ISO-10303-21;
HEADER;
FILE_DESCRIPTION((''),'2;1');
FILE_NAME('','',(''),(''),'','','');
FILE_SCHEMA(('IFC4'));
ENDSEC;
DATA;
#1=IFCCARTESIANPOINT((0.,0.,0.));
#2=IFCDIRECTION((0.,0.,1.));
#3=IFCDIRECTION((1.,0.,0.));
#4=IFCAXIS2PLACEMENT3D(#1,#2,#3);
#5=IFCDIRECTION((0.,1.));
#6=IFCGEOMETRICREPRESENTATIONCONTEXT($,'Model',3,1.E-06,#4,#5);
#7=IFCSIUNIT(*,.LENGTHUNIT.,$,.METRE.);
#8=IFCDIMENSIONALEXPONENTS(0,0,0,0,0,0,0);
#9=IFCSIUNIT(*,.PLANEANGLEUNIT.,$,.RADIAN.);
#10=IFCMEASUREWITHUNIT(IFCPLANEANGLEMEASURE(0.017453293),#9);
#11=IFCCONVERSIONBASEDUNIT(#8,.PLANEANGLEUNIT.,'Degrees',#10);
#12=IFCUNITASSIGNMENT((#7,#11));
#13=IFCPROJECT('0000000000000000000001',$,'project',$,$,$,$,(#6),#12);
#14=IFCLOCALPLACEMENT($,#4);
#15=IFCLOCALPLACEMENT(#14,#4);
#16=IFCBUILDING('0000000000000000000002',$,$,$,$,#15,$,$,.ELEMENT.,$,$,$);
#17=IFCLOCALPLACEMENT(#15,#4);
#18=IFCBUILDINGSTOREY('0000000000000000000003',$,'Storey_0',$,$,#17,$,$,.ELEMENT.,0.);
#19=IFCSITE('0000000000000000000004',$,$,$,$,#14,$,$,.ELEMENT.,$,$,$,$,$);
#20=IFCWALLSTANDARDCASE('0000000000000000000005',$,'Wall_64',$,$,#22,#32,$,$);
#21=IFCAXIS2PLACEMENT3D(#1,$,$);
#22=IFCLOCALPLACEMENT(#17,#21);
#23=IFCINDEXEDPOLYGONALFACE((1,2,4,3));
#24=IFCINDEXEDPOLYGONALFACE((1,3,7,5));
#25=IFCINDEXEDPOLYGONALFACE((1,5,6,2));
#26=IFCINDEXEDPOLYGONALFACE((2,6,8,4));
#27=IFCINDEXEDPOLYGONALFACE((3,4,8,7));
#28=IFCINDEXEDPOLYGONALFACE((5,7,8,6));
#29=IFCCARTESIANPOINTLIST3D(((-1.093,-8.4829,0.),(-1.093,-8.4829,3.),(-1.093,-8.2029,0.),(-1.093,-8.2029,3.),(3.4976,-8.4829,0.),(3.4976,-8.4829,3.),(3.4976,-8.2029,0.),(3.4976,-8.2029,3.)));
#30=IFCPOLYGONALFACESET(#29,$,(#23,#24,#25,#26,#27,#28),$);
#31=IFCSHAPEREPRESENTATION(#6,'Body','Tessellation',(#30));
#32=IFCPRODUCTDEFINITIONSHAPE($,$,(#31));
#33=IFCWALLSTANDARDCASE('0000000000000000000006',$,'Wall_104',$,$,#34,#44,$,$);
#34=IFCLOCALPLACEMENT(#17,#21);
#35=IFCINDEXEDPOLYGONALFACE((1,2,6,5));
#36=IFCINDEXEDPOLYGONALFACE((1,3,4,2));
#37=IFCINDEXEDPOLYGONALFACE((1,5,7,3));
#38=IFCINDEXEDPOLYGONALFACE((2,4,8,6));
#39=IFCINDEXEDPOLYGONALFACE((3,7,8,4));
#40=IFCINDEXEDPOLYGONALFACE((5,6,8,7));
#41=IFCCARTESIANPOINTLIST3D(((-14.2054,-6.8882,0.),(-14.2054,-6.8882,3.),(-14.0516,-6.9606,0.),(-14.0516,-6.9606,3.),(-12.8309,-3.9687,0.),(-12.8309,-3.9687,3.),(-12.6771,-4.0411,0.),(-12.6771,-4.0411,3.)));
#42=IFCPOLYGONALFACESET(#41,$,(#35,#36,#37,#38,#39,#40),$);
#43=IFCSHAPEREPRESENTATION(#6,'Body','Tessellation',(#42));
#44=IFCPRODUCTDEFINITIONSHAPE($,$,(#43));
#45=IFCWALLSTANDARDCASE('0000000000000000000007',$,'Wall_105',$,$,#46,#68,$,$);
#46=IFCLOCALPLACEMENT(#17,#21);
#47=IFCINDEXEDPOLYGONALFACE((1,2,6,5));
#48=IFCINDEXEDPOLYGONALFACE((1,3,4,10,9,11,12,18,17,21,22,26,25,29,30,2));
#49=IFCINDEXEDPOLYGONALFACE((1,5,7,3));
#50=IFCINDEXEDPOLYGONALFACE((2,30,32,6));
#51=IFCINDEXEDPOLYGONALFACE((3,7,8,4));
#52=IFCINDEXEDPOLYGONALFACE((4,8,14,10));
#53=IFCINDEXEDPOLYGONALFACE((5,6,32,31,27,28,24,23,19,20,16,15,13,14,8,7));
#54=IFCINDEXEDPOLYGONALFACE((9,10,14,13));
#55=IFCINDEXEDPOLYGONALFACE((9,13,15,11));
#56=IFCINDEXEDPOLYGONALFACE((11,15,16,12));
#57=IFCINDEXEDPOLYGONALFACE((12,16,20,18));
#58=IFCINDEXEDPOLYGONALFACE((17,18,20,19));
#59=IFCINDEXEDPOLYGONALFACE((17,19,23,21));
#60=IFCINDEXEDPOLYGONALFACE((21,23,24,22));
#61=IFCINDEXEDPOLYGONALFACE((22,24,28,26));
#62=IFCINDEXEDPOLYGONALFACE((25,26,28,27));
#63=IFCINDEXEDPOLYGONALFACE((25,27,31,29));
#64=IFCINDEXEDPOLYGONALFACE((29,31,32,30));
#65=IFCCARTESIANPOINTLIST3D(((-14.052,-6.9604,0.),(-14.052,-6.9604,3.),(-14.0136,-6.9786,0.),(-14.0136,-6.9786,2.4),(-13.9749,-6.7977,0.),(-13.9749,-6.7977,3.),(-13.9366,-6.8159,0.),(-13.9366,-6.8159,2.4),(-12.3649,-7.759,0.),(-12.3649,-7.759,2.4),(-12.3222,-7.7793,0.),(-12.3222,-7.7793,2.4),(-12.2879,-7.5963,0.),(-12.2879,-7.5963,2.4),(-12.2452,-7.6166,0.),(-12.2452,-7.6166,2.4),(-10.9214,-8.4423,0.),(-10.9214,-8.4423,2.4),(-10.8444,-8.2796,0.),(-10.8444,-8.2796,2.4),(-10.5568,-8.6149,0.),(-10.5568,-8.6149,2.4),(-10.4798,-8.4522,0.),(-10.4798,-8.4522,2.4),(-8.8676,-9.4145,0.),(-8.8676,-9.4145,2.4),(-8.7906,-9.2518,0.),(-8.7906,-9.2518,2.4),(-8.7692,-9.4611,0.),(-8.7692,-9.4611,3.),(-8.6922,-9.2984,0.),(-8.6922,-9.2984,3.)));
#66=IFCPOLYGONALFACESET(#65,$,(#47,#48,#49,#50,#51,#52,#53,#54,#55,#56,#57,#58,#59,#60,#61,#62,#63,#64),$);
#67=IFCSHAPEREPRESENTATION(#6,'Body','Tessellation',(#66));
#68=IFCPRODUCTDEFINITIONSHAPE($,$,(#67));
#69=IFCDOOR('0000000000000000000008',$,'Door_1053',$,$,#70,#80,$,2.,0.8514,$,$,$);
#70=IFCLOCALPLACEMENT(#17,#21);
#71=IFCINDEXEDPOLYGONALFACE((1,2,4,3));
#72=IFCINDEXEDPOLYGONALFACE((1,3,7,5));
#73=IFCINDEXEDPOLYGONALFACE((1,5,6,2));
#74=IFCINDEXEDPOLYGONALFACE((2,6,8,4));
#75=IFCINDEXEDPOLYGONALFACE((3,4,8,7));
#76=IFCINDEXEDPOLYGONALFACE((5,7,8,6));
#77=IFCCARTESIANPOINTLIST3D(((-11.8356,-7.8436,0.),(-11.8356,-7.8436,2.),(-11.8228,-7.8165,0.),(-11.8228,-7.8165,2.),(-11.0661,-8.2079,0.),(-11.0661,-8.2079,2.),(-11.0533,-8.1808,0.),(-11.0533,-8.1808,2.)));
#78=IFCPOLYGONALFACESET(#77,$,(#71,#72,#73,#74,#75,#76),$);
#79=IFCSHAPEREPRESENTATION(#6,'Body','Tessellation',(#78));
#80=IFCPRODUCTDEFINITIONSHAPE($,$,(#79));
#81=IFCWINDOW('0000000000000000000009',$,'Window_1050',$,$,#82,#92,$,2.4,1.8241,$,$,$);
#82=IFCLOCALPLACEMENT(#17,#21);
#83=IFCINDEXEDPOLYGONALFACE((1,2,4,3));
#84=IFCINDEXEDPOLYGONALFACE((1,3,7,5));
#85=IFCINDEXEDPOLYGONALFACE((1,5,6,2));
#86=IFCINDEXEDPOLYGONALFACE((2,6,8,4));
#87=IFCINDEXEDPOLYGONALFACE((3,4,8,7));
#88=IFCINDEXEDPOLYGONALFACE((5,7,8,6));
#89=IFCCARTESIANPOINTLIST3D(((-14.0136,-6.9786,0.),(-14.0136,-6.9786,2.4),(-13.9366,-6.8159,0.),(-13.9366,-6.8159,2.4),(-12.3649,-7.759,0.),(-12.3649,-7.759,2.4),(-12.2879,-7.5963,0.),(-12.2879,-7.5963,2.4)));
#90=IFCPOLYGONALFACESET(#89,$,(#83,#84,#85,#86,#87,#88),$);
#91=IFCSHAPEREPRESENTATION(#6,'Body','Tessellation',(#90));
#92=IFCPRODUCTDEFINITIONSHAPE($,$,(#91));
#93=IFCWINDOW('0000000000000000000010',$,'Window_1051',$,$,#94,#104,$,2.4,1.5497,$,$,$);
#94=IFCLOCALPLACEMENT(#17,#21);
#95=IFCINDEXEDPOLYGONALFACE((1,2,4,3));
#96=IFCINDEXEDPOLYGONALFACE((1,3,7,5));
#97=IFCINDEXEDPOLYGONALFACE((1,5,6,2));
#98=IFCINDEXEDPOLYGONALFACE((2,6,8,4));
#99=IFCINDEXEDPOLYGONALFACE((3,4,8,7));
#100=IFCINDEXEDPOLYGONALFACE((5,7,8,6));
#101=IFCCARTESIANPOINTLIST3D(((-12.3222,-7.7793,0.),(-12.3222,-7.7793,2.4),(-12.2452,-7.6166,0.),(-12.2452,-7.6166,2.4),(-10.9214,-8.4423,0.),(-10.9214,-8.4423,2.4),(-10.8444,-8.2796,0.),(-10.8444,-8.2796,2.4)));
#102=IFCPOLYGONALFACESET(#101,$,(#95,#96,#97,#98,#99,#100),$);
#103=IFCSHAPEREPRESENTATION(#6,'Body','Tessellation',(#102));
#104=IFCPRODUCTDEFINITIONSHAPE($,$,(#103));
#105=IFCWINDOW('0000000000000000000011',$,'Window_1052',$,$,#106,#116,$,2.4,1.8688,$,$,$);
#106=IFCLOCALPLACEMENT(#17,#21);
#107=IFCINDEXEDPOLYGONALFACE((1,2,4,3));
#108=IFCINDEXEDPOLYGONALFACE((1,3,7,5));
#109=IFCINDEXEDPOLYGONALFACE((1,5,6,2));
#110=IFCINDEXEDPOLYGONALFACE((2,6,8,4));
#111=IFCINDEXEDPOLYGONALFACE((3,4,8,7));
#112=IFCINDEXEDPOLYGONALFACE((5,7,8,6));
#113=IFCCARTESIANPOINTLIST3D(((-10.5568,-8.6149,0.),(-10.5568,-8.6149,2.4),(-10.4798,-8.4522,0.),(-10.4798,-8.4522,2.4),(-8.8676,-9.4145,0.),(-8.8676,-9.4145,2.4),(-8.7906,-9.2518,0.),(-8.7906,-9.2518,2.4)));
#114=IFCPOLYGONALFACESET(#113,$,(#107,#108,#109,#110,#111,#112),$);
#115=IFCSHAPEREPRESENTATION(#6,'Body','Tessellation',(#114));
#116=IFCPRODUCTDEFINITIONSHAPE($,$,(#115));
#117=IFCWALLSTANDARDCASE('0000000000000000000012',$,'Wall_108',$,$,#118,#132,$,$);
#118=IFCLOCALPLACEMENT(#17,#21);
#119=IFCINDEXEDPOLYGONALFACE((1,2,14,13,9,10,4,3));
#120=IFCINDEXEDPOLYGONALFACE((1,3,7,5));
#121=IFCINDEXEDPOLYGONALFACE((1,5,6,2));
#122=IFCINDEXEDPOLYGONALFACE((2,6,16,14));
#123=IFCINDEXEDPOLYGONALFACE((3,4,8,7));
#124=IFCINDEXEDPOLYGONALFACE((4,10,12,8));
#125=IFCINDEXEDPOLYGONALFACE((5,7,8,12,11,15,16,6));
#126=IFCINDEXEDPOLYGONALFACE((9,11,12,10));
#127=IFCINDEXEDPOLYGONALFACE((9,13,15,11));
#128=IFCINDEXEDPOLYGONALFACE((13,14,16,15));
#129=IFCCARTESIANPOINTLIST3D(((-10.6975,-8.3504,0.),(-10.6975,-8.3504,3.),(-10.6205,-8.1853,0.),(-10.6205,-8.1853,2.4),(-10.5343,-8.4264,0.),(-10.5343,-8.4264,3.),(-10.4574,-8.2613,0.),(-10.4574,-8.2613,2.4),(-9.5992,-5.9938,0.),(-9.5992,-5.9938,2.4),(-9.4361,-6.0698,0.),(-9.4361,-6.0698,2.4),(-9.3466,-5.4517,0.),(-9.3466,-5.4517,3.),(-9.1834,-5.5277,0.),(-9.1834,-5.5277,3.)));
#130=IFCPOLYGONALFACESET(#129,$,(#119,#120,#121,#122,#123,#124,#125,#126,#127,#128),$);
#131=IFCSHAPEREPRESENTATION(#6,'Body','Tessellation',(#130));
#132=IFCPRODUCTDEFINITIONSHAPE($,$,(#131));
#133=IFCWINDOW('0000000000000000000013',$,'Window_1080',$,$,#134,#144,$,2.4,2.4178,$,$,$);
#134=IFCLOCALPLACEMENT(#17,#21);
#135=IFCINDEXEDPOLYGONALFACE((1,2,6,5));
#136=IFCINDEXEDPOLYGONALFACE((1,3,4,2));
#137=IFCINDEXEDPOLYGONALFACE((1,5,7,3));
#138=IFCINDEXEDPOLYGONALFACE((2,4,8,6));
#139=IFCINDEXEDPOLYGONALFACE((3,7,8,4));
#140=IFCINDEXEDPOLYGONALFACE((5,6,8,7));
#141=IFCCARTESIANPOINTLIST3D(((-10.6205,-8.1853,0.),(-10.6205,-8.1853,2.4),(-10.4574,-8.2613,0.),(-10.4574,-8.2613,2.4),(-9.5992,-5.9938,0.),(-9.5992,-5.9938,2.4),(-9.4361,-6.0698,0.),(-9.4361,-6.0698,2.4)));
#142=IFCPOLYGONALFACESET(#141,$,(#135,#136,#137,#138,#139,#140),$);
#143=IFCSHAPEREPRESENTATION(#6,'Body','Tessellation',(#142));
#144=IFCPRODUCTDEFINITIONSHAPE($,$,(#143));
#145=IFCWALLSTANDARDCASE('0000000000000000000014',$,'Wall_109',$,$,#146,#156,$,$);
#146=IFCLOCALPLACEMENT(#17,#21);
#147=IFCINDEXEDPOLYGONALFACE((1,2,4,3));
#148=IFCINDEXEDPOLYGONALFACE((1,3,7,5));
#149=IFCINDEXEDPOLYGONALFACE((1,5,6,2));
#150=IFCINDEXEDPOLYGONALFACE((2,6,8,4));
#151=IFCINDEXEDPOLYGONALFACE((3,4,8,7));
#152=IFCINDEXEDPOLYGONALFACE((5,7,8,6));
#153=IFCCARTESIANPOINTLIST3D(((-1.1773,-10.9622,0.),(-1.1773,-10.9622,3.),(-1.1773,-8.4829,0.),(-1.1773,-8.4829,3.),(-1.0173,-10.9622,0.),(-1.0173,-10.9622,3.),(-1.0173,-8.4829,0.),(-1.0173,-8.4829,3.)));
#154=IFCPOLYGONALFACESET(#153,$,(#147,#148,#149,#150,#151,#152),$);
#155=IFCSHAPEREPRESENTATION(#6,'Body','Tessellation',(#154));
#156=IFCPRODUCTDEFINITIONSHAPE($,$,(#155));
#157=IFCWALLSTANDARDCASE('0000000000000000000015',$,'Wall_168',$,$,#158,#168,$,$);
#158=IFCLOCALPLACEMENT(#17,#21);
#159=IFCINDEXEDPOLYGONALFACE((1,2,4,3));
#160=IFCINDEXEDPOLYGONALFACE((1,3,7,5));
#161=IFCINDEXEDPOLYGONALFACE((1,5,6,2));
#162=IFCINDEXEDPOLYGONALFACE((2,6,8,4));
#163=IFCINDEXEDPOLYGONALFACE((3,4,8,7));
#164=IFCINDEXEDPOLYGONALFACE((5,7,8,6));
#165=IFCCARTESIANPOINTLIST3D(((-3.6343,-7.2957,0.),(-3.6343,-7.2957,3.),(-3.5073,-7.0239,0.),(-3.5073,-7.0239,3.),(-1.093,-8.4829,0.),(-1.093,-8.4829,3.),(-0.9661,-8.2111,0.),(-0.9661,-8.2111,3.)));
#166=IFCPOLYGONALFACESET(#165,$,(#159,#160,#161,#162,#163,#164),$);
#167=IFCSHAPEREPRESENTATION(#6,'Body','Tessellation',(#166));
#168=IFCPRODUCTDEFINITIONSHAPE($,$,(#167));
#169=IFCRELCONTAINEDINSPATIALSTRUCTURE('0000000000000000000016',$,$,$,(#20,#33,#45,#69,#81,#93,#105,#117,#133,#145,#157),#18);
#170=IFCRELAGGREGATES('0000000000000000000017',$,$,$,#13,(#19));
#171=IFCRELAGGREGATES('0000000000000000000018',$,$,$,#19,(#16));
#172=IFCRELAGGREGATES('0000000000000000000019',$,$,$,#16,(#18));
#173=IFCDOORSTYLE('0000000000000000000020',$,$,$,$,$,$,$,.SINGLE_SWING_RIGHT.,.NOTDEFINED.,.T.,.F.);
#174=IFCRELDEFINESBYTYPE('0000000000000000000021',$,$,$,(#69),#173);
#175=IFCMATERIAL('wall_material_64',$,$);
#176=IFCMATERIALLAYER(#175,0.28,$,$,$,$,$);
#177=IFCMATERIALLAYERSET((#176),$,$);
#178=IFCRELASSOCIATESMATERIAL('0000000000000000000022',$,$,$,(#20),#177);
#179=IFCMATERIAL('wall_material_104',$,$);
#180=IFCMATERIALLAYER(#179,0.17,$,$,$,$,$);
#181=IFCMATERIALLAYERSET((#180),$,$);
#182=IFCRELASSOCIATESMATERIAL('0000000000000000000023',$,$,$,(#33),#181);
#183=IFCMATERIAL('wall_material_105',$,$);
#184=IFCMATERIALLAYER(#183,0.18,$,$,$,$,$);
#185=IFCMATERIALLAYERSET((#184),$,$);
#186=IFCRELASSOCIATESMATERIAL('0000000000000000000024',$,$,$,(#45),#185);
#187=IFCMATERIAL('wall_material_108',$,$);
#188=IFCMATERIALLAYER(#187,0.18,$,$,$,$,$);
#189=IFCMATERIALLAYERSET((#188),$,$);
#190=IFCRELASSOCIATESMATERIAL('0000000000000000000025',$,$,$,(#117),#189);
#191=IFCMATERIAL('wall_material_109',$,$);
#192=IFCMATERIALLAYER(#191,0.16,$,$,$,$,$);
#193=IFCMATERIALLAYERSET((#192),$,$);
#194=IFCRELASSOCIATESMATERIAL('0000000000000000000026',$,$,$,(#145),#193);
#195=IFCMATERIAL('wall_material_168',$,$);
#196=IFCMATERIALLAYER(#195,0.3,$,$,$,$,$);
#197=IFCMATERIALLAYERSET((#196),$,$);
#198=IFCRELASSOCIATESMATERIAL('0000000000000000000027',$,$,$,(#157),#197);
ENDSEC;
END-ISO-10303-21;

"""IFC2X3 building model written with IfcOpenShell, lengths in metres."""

from ifc_helpers import new_model, entity, si_unit, converted_unit, direction, frame, frame_2d, origin_with_axes, place, context, project, spatial, polyline, rectangle, outline, extrude, material, layer, layer_set, layer_usage, type_object, element, fill, save


model = new_model("IFC2X3")

# Units and contexts
model_context = context("Model", 3, precision=1e-06, world=origin_with_axes(), true_north=direction((0.0, 1.0)))
ifc_project = project(units=[si_unit("LENGTHUNIT", "METRE"), converted_unit("PLANEANGLEUNIT", "Degrees", entity("IfcPlaneAngleMeasure", 0.017453293), si_unit("PLANEANGLEUNIT", "RADIAN"), dimensions=[0, 0, 0, 0, 0, 0, 0])], contexts=[model_context])

# Site, building, storey
site_placement = place(None, origin_with_axes())
site = spatial("IfcSite", under=ifc_project, at=site_placement, CompositionType="ELEMENT")
building_placement = place(site_placement, origin_with_axes())
building = spatial("IfcBuilding", under=site, at=building_placement, CompositionType="ELEMENT")
storey_placement = place(building_placement, origin_with_axes())
storey = spatial("IfcBuildingStorey", under=building, at=storey_placement, Name="Storey_0", CompositionType="ELEMENT", Elevation=0.0)

# Walls
ifc_material_1 = material(Name="wall_material_64")
ifc_layer_1 = layer(ifc_material_1, 0.28)
ifc_layer_set_1 = layer_set([ifc_layer_1])
ifc_layer_usage_1 = layer_usage(ifc_layer_set_1, "AXIS2", "NEGATIVE", 0.0)
wall_1_placement = place(storey_placement, frame((-1.093, -8.2029, 0.0), z_axis=(0.0, 0.0, 1.0), x_axis=(1.0, 0.0, 0.0)))
element("IfcWallStandardCase", 1, at=wall_1_placement, inside=storey, material=ifc_layer_usage_1, Name="Wall_64", context=model_context, shape_type="SweptSolid", body=[
    extrude(outline(polyline([(0.0, 0.0), (4.5907, 0.0), (4.5907, -0.28), (0.0, -0.28), (0.0, 0.0)])), origin_with_axes(), (0.0, 0.0, 1.0), 3.0),
])
ifc_material_2 = material(Name="wall_material_104")
ifc_layer_2 = layer(ifc_material_2, 0.17)
ifc_layer_set_2 = layer_set([ifc_layer_2])
ifc_layer_usage_2 = layer_usage(ifc_layer_set_2, "AXIS2", "POSITIVE", 0.0)
wall_2_placement = place(storey_placement, frame((-12.8309, -3.9687, 0.0), z_axis=(0.0, 0.0, 1.0), x_axis=(-0.425973, -0.904736, 0.0)))
element("IfcWallStandardCase", 2, at=wall_2_placement, inside=storey, material=ifc_layer_usage_2, Name="Wall_104", context=model_context, shape_type="SweptSolid", body=[
    extrude(outline(polyline([(0.0, 0.17), (3.2269, 0.17), (3.2269, 0.0), (0.0, 0.0), (0.0, 0.17)])), origin_with_axes(), (0.0, 0.0, 1.0), 3.0),
])

# Wall, openings, door, windows
ifc_material_3 = material(Name="wall_material_105")
ifc_layer_3 = layer(ifc_material_3, 0.18)
ifc_layer_set_3 = layer_set([ifc_layer_3])
ifc_layer_usage_3 = layer_usage(ifc_layer_set_3, "AXIS2", "POSITIVE", 0.0)
wall_3_placement = place(storey_placement, frame((-14.052, -6.9604, 0.0), z_axis=(0.0, 0.0, 1.0), x_axis=(0.90385, -0.42785, 0.0)))
wall_3 = element("IfcWallStandardCase", 3, at=wall_3_placement, inside=storey, material=ifc_layer_usage_3, Name="Wall_105", context=model_context, shape_type="SweptSolid", body=[
    extrude(outline(polyline([(0.0, 0.18), (5.8447, 0.18), (5.8447, 0.0), (0.0, 0.0), (0.0, 0.18)])), origin_with_axes(), (0.0, 0.0, 1.0), 3.0),
])
opening_1_placement = place(wall_3_placement, frame((0.0424, 0.18, 0.0), z_axis=(0.0, 0.0, 1.0), x_axis=(1.0, 0.0, 0.0)))
opening_1 = element("IfcOpeningElement", 4, at=opening_1_placement, cuts=wall_3, context=model_context, shape_type="SweptSolid", body=[
    extrude(rectangle(XDim=1.8241, YDim=2.4, at=frame_2d((1.2, -0.912), x_axis=(0.0, 1.0))), frame((0.0, 0.01, 0.0), z_axis=(0.0, -1.0, 0.0), x_axis=(0.0, 0.0, 1.0)), (0.0, 0.0, 1.0), 0.2),
])
opening_2_placement = place(wall_3_placement, frame((1.9138, 0.18, 0.0), z_axis=(0.0, 0.0, 1.0), x_axis=(1.0, 0.0, 0.0)))
opening_2 = element("IfcOpeningElement", 5, at=opening_2_placement, cuts=wall_3, context=model_context, shape_type="SweptSolid", body=[
    extrude(rectangle(XDim=1.5497, YDim=2.4, at=frame_2d((1.2, -0.7749), x_axis=(0.0, 1.0))), frame((0.0, 0.01, 0.0), z_axis=(0.0, -1.0, 0.0), x_axis=(0.0, 0.0, 1.0)), (0.0, 0.0, 1.0), 0.2),
])
opening_3_placement = place(wall_3_placement, frame((3.867, 0.18, 0.0), z_axis=(0.0, 0.0, 1.0), x_axis=(1.0, 0.0, 0.0)))
opening_3 = element("IfcOpeningElement", 6, at=opening_3_placement, cuts=wall_3, context=model_context, shape_type="SweptSolid", body=[
    extrude(rectangle(XDim=1.8688, YDim=2.4, at=frame_2d((1.2, -0.9344), x_axis=(0.0, 1.0))), frame((0.0, 0.01, 0.0), z_axis=(0.0, -1.0, 0.0), x_axis=(0.0, 0.0, 1.0)), (0.0, 0.0, 1.0), 0.2),
])
opening_4_placement = place(wall_3_placement, frame((2.3811, 0.18, 0.0), z_axis=(0.0, 0.0, 1.0), x_axis=(1.0, 0.0, 0.0)))
opening_4 = element("IfcOpeningElement", 7, at=opening_4_placement, cuts=wall_3, context=model_context, shape_type="SweptSolid", body=[
    extrude(rectangle(XDim=0.8514, YDim=2.0, at=frame_2d((1.0, -0.4257), x_axis=(0.0, 1.0))), frame((0.0, 0.01, 0.0), z_axis=(0.0, -1.0, 0.0), x_axis=(0.0, 0.0, 1.0)), (0.0, 0.0, 1.0), 0.2),
])
door_style = type_object("IfcDoorStyle", ConstructionType="NOTDEFINED", OperationType="SINGLE_SWING_RIGHT", ParameterTakesPrecedence=True, Sizeable=False)
door_placement = place(storey_placement, origin_with_axes())
door = element("IfcDoor", 8, at=door_placement, inside=storey, type_object=door_style, Name="Door_1053", OverallHeight=2.0, OverallWidth=0.8514, context=model_context, shape_type="SweptSolid", body=[
    extrude(outline(polyline([(-11.8228, -7.8165), (-11.0533, -8.1808), (-11.0661, -8.2079), (-11.8356, -7.8436), (-11.8228, -7.8165)])), origin_with_axes(), (0.0, 0.0, 1.0), 2.0),
])
fill(opening_4, door)
window_1_placement = place(storey_placement, origin_with_axes())
window_1 = element("IfcWindow", 9, at=window_1_placement, inside=storey, Name="Window_1050", OverallHeight=2.4, OverallWidth=1.8241, context=model_context, shape_type="SweptSolid", body=[
    extrude(outline(polyline([(-13.9366, -6.8159), (-12.2879, -7.5963), (-12.3649, -7.759), (-14.0136, -6.9786), (-13.9366, -6.8159)])), origin_with_axes(), (0.0, 0.0, 1.0), 2.4),
])
fill(opening_1, window_1)
window_2_placement = place(storey_placement, origin_with_axes())
window_2 = element("IfcWindow", 10, at=window_2_placement, inside=storey, Name="Window_1051", OverallHeight=2.4, OverallWidth=1.5497, context=model_context, shape_type="SweptSolid", body=[
    extrude(outline(polyline([(-12.2452, -7.6166), (-10.8444, -8.2796), (-10.9214, -8.4423), (-12.3222, -7.7793), (-12.2452, -7.6166)])), origin_with_axes(), (0.0, 0.0, 1.0), 2.4),
])
fill(opening_2, window_2)
window_3_placement = place(storey_placement, origin_with_axes())
window_3 = element("IfcWindow", 11, at=window_3_placement, inside=storey, Name="Window_1052", OverallHeight=2.4, OverallWidth=1.8688, context=model_context, shape_type="SweptSolid", body=[
    extrude(outline(polyline([(-10.4798, -8.4522), (-8.7906, -9.2518), (-8.8676, -9.4145), (-10.5568, -8.6149), (-10.4798, -8.4522)])), origin_with_axes(), (0.0, 0.0, 1.0), 2.4),
])
fill(opening_3, window_3)

# Wall, opening, window
ifc_material_4 = material(Name="wall_material_108")
ifc_layer_4 = layer(ifc_material_4, 0.18)
ifc_layer_set_4 = layer_set([ifc_layer_4])
ifc_layer_usage_4 = layer_usage(ifc_layer_set_4, "AXIS2", "NEGATIVE", 0.0)
wall_4_placement = place(storey_placement, frame((-10.6975, -8.3504, 0.0), z_axis=(0.0, 0.0, 1.0), x_axis=(0.422403, 0.906408, 0.0)))
wall_4 = element("IfcWallStandardCase", 12, at=wall_4_placement, inside=storey, material=ifc_layer_usage_4, Name="Wall_108", context=model_context, shape_type="SweptSolid", body=[
    extrude(outline(polyline([(0.0, 0.0), (3.198, 0.0), (3.198, -0.18), (0.0, -0.18), (0.0, 0.0)])), origin_with_axes(), (0.0, 0.0, 1.0), 3.0),
])
opening_5_placement = place(wall_4_placement, frame((0.1822, 0.0, 0.0), z_axis=(0.0, 0.0, 1.0), x_axis=(1.0, 0.0, 0.0)))
opening_5 = element("IfcOpeningElement", 13, at=opening_5_placement, cuts=wall_4, context=model_context, shape_type="SweptSolid", body=[
    extrude(rectangle(XDim=2.4178, YDim=2.4, at=frame_2d((1.2, -1.2089), x_axis=(0.0, 1.0))), frame((0.0, 0.01, 0.0), z_axis=(0.0, -1.0, 0.0), x_axis=(0.0, 0.0, 1.0)), (0.0, 0.0, 1.0), 0.2),
])
window_4_placement = place(storey_placement, origin_with_axes())
window_4 = element("IfcWindow", 14, at=window_4_placement, inside=storey, Name="Window_1080", OverallHeight=2.4, OverallWidth=2.4178, context=model_context, shape_type="SweptSolid", body=[
    extrude(outline(polyline([(-10.6205, -8.1853), (-9.5992, -5.9938), (-9.4361, -6.0698), (-10.4574, -8.2613), (-10.6205, -8.1853)])), origin_with_axes(), (0.0, 0.0, 1.0), 2.4),
])
fill(opening_5, window_4)

# Walls
ifc_material_5 = material(Name="wall_material_109")
ifc_layer_5 = layer(ifc_material_5, 0.16)
ifc_layer_set_5 = layer_set([ifc_layer_5])
ifc_layer_usage_5 = layer_usage(ifc_layer_set_5, "AXIS2", "NEGATIVE", 0.0)
wall_5_placement = place(storey_placement, frame((-1.0173, -8.4829, 0.0), z_axis=(0.0, 0.0, 1.0), x_axis=(0.0, -1.0, 0.0)))
element("IfcWallStandardCase", 15, at=wall_5_placement, inside=storey, material=ifc_layer_usage_5, Name="Wall_109", context=model_context, shape_type="SweptSolid", body=[
    extrude(outline(polyline([(0.0, 0.0), (2.4793, 0.0), (2.4793, -0.16), (0.0, -0.16), (0.0, 0.0)])), origin_with_axes(), (0.0, 0.0, 1.0), 3.0),
])
ifc_material_6 = material(Name="wall_material_168")
ifc_layer_6 = layer(ifc_material_6, 0.3)
ifc_layer_set_6 = layer_set([ifc_layer_6])
ifc_layer_usage_6 = layer_usage(ifc_layer_set_6, "AXIS2", "NEGATIVE", 0.0)
wall_6_placement = place(storey_placement, frame((-1.093, -8.4829, 0.0), z_axis=(0.0, 0.0, 1.0), x_axis=(-0.906013, 0.423251, 0.0)))
element("IfcWallStandardCase", 16, at=wall_6_placement, inside=storey, material=ifc_layer_usage_6, Name="Wall_168", context=model_context, shape_type="SweptSolid", body=[
    extrude(outline(polyline([(0.0, 0.0), (2.8049, 0.0), (2.8049, -0.3), (0.0, -0.3), (0.0, 0.0)])), origin_with_axes(), (0.0, 0.0, 1.0), 3.0),
])

save(model, "model.ifc")
